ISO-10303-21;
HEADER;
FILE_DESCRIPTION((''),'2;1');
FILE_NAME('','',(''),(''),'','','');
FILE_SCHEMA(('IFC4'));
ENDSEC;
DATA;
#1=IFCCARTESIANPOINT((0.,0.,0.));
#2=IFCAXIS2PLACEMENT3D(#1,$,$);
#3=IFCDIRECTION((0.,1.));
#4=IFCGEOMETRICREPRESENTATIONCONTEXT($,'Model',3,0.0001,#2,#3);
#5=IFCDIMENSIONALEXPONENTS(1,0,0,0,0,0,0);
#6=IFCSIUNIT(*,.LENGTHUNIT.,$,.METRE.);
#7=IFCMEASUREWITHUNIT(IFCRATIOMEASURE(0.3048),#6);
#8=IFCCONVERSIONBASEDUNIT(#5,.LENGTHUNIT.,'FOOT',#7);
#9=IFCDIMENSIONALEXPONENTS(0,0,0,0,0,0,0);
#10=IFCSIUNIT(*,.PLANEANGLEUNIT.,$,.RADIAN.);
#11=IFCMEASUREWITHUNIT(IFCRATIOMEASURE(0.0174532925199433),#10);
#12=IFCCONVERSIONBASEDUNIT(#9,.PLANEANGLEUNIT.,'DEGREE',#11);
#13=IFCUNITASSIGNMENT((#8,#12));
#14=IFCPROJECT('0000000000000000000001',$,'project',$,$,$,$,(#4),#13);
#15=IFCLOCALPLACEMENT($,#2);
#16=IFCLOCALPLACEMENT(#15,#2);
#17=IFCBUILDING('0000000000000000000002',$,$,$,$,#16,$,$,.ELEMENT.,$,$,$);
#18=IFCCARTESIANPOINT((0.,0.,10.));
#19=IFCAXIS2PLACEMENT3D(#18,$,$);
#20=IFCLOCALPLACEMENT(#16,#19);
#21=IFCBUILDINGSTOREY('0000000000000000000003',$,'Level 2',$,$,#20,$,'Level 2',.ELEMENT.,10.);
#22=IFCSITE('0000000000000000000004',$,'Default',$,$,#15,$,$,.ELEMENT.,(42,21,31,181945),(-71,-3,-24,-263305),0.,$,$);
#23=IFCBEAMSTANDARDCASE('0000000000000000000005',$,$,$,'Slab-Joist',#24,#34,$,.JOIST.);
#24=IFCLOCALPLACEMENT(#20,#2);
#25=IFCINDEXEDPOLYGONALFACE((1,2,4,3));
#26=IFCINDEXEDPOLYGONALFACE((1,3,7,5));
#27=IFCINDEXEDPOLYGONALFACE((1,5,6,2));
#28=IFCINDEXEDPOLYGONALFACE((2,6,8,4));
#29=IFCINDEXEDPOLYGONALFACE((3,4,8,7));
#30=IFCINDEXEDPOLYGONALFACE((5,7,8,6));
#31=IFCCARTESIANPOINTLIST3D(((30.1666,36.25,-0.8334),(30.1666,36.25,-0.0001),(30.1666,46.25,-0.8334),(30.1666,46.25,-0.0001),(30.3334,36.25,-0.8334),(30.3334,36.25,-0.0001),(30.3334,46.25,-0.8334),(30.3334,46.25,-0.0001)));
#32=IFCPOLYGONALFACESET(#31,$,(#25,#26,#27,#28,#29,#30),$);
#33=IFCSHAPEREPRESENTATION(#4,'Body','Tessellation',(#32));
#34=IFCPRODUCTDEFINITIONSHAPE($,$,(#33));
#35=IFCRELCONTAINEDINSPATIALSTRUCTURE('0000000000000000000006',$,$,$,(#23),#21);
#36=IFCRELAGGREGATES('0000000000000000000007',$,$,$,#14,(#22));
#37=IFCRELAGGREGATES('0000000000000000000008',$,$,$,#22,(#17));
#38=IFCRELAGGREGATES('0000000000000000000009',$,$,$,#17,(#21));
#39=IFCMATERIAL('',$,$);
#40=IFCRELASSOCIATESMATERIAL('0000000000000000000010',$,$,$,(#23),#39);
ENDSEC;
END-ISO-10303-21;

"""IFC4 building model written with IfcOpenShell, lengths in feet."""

from ifc_helpers import new_model, entity, si_unit, converted_unit, direction, frame, origin, origin_with_axes, place, context, project, spatial, rectangle, extrude, material, element, save


model = new_model("IFC4")

# Units and contexts
model_context = context("Model", 3, precision=0.0001, world=origin(), true_north=direction((0.0, 1.0)))
ifc_project = project(units=[converted_unit("LENGTHUNIT", "FOOT", entity("IfcRatioMeasure", 0.3048), si_unit("LENGTHUNIT", "METRE"), dimensions=[1, 0, 0, 0, 0, 0, 0]), converted_unit("PLANEANGLEUNIT", "DEGREE", entity("IfcRatioMeasure", 0.0174532925199433), si_unit("PLANEANGLEUNIT", "RADIAN"), dimensions=[0, 0, 0, 0, 0, 0, 0])], contexts=[model_context])

# Site, building, storey
site_placement = place(None, origin())
site = spatial("IfcSite", under=ifc_project, at=site_placement, Name="Default", CompositionType="ELEMENT", RefLatitude=(42, 21, 31, 181945), RefLongitude=(-71, -3, -24, -263305), RefElevation=0.0)
building_placement = place(site_placement, origin())
building = spatial("IfcBuilding", under=site, at=building_placement, CompositionType="ELEMENT")
storey_placement = place(building_placement, frame((0.0, 0.0, 10.0)))
storey = spatial("IfcBuildingStorey", under=building, at=storey_placement, Name="Level 2", LongName="Level 2", CompositionType="ELEMENT", Elevation=10.0)

# Beam
ifc_material = material(Name="")
placement_1 = place(storey_placement, frame((30.25, 36.25, 0.0), z_axis=(0.0, 0.0, 1.0), x_axis=(1.0, 0.0, 0.0)))
beam_1_placement = place(placement_1, frame((0.0, 0.0, -0.4167), z_axis=(0.0, 1.0, 0.0), x_axis=(-1.0, 0.0, 0.0)))
element("IfcBeamStandardCase", 1, at=beam_1_placement, inside=storey, material=ifc_material, ObjectType="Slab-Joist", PredefinedType="JOIST", context=model_context, shape_type="SweptSolid", body=[
    extrude(rectangle(XDim=0.1667, YDim=0.8333), origin_with_axes(), (0.0, 0.0, 1.0), 10.0),
])

save(model, "model.ifc")
